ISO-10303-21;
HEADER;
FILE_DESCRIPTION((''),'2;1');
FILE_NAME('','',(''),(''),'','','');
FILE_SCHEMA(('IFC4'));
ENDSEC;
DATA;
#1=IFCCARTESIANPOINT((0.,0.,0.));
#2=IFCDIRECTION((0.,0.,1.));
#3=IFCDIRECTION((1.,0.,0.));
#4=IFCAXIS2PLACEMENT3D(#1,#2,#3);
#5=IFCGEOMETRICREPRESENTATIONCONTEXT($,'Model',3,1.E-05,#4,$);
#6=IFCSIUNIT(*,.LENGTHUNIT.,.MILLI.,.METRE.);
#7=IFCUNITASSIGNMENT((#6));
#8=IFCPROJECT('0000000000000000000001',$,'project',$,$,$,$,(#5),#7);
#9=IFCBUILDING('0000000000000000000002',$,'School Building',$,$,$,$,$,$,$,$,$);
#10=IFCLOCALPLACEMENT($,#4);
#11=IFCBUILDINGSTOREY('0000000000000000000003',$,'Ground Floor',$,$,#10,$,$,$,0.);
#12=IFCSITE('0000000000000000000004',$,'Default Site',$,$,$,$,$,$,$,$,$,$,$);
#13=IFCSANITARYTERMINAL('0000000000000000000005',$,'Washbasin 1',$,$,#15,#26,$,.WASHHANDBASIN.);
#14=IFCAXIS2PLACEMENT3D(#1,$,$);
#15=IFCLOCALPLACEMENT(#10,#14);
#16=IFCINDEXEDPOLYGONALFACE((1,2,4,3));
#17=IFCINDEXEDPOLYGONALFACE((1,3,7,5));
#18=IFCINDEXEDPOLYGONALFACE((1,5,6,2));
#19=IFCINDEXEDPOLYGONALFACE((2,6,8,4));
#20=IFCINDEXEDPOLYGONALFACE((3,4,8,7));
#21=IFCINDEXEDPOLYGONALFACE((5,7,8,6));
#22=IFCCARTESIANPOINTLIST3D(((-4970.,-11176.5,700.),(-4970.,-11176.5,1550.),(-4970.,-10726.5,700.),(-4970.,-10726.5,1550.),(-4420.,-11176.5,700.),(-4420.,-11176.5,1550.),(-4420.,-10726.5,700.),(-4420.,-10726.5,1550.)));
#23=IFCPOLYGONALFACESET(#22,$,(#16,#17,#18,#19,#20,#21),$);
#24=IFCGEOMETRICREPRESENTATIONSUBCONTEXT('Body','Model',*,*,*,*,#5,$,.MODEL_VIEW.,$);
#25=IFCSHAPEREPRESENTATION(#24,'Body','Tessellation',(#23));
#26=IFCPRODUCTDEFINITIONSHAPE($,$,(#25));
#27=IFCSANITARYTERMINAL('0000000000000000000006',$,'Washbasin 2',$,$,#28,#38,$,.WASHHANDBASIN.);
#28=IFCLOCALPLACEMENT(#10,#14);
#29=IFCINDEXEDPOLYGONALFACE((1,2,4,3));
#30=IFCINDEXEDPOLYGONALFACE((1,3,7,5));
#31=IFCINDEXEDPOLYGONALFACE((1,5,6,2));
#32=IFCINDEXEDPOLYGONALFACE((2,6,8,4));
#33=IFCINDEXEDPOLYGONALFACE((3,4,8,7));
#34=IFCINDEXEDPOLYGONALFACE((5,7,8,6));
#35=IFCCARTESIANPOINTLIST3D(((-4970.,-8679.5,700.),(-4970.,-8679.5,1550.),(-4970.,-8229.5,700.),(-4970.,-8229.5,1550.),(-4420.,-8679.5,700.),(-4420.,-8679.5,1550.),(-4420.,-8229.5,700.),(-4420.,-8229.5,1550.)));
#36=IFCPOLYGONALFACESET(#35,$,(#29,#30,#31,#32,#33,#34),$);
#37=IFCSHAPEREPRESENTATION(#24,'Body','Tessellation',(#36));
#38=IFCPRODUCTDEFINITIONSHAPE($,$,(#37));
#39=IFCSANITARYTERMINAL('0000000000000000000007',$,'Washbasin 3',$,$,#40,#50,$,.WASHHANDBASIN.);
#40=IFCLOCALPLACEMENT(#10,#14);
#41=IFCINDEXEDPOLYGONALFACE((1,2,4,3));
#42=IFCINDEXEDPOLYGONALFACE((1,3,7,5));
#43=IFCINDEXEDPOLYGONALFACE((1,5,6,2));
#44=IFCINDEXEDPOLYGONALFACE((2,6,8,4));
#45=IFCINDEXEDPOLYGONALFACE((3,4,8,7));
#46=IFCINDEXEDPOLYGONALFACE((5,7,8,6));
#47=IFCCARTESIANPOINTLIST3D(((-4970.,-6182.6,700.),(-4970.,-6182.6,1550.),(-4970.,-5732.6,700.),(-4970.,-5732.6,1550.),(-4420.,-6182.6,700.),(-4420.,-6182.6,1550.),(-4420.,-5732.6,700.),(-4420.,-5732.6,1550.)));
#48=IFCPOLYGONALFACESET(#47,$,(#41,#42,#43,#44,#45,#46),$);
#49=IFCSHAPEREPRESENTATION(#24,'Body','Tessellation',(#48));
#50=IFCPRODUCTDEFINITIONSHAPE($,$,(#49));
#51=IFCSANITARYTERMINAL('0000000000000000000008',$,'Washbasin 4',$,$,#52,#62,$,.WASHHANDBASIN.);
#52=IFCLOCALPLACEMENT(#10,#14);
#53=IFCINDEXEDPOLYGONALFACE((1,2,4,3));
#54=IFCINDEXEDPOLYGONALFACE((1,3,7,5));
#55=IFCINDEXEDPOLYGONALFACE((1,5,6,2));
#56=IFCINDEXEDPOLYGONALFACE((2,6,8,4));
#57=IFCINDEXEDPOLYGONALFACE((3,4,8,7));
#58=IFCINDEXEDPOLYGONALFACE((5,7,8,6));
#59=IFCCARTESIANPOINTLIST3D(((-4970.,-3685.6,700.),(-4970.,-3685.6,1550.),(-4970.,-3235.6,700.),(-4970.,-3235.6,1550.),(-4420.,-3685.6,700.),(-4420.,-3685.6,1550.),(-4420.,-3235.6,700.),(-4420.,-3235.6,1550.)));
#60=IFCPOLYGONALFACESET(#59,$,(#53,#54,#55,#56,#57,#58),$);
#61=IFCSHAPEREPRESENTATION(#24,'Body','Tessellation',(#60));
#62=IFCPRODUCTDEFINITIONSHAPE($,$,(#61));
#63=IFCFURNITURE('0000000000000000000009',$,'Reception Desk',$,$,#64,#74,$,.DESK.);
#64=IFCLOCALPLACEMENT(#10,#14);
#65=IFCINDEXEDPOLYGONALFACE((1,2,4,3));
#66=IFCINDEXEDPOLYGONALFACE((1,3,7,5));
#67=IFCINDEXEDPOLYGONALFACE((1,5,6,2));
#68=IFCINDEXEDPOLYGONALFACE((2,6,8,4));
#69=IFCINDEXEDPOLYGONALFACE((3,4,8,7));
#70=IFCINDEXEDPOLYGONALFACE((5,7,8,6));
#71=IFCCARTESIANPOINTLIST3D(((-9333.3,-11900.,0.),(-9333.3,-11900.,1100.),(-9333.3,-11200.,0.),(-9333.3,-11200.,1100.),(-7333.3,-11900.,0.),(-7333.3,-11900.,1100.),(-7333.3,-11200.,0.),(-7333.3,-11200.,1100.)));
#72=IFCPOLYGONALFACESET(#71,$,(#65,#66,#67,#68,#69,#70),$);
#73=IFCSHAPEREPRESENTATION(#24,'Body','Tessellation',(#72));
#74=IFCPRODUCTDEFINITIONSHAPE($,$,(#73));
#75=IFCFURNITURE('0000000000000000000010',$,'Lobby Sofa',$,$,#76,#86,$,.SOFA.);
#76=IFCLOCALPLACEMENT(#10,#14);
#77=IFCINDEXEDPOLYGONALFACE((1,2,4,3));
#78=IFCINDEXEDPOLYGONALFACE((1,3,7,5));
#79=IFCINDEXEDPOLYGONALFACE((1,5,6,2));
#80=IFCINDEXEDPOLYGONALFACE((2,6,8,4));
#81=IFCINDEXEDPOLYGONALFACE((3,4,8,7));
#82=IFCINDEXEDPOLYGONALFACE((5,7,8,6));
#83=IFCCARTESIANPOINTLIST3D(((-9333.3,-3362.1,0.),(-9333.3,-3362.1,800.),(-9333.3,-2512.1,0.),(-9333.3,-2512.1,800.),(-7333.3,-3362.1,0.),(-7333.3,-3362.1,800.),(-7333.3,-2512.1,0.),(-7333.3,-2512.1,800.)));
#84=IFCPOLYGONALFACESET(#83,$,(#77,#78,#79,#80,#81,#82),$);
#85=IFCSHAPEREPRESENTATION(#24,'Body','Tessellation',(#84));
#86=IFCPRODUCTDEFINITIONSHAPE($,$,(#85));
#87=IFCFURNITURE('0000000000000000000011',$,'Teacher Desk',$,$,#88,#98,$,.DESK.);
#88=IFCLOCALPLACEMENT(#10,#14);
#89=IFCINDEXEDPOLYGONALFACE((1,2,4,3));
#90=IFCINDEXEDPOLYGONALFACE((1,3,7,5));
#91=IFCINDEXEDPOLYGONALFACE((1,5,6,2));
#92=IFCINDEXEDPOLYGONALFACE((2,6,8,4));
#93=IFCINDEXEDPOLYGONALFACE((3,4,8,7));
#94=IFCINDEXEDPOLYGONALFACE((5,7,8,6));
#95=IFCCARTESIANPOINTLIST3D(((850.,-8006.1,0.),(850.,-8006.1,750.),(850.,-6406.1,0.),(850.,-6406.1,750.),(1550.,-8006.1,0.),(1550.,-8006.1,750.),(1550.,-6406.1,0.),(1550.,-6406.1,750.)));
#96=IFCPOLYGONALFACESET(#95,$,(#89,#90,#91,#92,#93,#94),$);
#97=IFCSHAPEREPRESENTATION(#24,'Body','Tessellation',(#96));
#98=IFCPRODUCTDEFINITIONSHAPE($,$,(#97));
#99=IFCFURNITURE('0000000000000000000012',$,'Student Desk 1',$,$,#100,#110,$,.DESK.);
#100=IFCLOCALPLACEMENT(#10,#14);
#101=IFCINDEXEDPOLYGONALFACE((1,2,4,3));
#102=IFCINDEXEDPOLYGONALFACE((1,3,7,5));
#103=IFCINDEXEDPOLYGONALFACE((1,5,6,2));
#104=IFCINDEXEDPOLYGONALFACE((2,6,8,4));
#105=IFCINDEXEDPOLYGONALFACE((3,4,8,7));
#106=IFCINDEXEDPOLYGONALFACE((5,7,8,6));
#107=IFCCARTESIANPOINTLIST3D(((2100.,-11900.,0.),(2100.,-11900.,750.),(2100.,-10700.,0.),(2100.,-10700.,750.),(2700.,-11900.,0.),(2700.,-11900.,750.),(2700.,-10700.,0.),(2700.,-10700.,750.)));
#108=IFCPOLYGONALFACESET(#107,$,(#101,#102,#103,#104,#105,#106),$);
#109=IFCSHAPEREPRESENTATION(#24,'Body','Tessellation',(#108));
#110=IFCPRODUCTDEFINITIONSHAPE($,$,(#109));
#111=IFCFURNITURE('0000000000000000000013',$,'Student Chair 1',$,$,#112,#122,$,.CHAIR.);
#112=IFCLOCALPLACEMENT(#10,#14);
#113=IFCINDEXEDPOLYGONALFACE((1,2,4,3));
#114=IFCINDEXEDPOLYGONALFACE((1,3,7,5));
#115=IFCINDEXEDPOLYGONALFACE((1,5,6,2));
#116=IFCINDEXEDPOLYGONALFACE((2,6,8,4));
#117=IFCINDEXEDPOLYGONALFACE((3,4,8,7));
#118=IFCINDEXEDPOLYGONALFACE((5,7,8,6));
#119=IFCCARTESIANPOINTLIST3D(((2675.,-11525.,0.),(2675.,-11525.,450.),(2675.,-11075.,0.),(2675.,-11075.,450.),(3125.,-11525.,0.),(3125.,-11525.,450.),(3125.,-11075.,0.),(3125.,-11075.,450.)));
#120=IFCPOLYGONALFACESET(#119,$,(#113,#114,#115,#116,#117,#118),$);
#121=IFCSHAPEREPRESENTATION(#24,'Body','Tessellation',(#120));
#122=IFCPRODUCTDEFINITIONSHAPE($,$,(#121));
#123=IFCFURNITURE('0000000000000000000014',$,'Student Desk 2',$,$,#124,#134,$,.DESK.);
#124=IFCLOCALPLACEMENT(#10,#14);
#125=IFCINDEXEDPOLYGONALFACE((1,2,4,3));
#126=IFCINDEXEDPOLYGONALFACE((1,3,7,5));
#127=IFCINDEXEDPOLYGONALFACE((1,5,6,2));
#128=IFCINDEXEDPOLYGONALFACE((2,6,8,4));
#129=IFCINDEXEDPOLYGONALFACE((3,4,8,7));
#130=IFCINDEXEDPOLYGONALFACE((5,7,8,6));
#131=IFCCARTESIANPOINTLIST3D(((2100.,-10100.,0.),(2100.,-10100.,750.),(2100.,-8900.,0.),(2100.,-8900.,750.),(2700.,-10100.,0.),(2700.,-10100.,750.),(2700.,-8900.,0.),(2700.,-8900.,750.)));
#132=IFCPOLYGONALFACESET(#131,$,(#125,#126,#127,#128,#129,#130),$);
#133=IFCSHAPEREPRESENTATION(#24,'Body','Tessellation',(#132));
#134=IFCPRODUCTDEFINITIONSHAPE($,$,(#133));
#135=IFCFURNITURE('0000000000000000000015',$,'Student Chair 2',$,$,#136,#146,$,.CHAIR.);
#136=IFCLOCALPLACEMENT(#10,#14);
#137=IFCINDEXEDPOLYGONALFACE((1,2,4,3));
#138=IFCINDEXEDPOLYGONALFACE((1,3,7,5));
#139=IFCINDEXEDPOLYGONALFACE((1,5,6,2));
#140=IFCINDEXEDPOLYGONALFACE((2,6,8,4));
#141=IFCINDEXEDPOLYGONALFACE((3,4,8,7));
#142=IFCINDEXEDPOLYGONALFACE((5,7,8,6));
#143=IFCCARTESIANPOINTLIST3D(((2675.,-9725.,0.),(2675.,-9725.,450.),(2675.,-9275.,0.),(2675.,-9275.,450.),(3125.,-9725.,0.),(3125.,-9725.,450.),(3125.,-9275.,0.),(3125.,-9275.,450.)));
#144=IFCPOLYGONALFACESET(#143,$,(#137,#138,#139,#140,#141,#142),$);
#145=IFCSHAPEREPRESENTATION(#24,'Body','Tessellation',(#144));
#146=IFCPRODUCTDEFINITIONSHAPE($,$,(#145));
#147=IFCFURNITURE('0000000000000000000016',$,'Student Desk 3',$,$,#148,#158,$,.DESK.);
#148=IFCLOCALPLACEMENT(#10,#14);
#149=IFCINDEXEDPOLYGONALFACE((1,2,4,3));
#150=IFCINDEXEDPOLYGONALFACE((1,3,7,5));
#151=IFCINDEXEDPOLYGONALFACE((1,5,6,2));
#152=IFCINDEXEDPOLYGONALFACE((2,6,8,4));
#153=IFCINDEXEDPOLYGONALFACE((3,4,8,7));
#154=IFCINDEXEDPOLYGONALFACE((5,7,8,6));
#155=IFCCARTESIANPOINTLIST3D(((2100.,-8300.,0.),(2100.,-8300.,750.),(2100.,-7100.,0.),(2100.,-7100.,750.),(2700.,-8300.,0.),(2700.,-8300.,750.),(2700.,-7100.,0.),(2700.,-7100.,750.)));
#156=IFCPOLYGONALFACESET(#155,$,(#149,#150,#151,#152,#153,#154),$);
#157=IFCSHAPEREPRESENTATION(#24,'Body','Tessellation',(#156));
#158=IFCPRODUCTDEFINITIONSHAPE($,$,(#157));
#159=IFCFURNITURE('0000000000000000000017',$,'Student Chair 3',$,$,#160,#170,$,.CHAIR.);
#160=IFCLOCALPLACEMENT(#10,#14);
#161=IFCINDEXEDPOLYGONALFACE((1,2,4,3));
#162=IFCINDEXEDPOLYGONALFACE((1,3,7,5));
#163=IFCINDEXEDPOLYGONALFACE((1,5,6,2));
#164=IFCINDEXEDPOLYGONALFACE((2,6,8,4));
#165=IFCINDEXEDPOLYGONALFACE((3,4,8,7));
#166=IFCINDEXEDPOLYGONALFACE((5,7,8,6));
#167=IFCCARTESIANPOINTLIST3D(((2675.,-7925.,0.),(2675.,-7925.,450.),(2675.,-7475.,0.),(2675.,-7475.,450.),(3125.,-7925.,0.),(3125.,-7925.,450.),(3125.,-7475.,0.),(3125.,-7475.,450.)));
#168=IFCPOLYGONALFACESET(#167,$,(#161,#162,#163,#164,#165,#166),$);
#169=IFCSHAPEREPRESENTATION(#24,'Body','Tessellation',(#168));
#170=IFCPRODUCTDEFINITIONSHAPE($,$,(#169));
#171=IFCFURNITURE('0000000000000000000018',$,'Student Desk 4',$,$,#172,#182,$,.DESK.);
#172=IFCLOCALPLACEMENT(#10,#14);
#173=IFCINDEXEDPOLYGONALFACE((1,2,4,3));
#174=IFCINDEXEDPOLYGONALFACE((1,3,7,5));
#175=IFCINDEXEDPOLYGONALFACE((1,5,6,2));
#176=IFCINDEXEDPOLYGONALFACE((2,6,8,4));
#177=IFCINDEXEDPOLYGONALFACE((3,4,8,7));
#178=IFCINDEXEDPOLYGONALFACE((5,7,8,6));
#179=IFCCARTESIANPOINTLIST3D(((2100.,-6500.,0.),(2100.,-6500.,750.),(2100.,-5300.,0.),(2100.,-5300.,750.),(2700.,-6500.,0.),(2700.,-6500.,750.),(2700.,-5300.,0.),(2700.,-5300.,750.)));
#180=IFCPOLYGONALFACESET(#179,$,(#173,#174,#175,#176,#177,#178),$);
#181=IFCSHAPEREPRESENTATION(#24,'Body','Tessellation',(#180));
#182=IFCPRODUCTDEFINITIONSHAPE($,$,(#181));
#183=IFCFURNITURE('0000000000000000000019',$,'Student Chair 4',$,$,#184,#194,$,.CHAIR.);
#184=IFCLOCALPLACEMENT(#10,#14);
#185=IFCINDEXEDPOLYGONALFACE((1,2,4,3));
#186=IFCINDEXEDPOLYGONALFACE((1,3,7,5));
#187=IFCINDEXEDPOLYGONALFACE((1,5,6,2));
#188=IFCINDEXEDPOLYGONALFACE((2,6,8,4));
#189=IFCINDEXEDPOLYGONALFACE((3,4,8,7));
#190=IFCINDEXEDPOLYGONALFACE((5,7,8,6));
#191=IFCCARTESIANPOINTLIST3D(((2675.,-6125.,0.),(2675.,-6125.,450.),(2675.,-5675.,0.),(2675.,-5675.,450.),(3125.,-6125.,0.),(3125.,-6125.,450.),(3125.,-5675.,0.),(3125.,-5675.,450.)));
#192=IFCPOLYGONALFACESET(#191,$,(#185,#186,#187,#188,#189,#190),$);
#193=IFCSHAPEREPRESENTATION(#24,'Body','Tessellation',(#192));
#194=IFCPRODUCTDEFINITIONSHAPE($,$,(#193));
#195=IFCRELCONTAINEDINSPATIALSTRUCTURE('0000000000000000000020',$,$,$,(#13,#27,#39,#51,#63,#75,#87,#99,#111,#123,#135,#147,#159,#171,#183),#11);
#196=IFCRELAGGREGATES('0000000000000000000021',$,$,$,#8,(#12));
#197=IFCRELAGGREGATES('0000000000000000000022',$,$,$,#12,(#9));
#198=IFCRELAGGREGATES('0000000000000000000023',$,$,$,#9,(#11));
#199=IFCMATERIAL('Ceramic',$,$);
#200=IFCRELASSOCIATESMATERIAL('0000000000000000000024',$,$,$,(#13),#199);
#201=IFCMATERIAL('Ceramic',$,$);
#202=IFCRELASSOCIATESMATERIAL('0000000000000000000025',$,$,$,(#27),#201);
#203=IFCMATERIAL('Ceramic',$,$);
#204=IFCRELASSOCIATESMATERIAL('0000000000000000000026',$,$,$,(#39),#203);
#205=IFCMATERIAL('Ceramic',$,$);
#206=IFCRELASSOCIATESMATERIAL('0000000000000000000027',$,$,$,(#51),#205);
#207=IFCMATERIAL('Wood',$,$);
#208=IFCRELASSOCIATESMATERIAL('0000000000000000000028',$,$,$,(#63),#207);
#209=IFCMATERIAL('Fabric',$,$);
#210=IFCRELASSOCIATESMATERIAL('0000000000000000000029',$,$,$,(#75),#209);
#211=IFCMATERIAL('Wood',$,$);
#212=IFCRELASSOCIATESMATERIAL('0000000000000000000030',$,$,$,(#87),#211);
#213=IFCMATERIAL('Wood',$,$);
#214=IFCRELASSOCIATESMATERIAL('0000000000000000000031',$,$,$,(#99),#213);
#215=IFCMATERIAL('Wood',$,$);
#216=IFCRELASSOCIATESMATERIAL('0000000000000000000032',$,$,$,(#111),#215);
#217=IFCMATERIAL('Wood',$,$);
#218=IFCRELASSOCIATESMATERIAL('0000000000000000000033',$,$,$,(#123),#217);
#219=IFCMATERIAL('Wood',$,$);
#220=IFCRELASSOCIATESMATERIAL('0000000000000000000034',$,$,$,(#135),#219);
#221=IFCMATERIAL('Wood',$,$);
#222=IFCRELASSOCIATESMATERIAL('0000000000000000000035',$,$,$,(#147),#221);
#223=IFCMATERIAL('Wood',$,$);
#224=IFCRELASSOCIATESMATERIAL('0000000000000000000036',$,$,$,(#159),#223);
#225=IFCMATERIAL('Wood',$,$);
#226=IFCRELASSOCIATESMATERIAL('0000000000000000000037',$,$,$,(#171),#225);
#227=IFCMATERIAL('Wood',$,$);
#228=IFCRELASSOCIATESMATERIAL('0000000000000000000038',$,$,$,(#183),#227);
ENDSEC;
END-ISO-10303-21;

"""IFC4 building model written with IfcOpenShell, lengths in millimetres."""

from ifc_helpers import new_model, si_unit, frame, origin_with_axes, origin_2d, place, context, subcontext, project, spatial, rectangle, extrude, material, element, save


model = new_model("IFC4")

# Units and contexts
model_context = context("Model", 3, precision=1e-05, world=origin_with_axes())
body_context = subcontext(model_context, "Body", "Model", "MODEL_VIEW")
ifc_project = project(units=[si_unit("LENGTHUNIT", "METRE", prefix="MILLI")], contexts=[model_context])

# Site, building, storey
site = spatial("IfcSite", under=ifc_project, Name="Default Site")
building = spatial("IfcBuilding", under=site, Name="School Building")
storey_placement = place(None, origin_with_axes())
storey = spatial("IfcBuildingStorey", under=building, at=storey_placement, Name="Ground Floor", Elevation=0.0)

# Sanitary terminals
ifc_material_1 = material(Name="Ceramic")
sanitary_terminal_1_placement = place(storey_placement, frame((-4695.0, -10951.5, 700.0), z_axis=(0.0, 0.0, 1.0), x_axis=(0.0, 1.0, 0.0)))
element("IfcSanitaryTerminal", 1, at=sanitary_terminal_1_placement, inside=storey, material=ifc_material_1, Name="Washbasin 1", PredefinedType="WASHHANDBASIN", context=body_context, shape_type="SweptSolid", body=[
    extrude(rectangle(XDim=450.0, YDim=550.0, at=origin_2d()), origin_with_axes(), (0.0, 0.0, 1.0), 850.0),
])
ifc_material_2 = material(Name="Ceramic")
sanitary_terminal_2_placement = place(storey_placement, frame((-4695.0, -8454.5, 700.0), z_axis=(0.0, 0.0, 1.0), x_axis=(0.0, 1.0, 0.0)))
element("IfcSanitaryTerminal", 2, at=sanitary_terminal_2_placement, inside=storey, material=ifc_material_2, Name="Washbasin 2", PredefinedType="WASHHANDBASIN", context=body_context, shape_type="SweptSolid", body=[
    extrude(rectangle(XDim=450.0, YDim=550.0, at=origin_2d()), origin_with_axes(), (0.0, 0.0, 1.0), 850.0),
])
ifc_material_3 = material(Name="Ceramic")
sanitary_terminal_3_placement = place(storey_placement, frame((-4695.0, -5957.6, 700.0), z_axis=(0.0, 0.0, 1.0), x_axis=(0.0, 1.0, 0.0)))
element("IfcSanitaryTerminal", 3, at=sanitary_terminal_3_placement, inside=storey, material=ifc_material_3, Name="Washbasin 3", PredefinedType="WASHHANDBASIN", context=body_context, shape_type="SweptSolid", body=[
    extrude(rectangle(XDim=450.0, YDim=550.0, at=origin_2d()), origin_with_axes(), (0.0, 0.0, 1.0), 850.0),
])
ifc_material_4 = material(Name="Ceramic")
sanitary_terminal_4_placement = place(storey_placement, frame((-4695.0, -3460.6, 700.0), z_axis=(0.0, 0.0, 1.0), x_axis=(0.0, 1.0, 0.0)))
element("IfcSanitaryTerminal", 4, at=sanitary_terminal_4_placement, inside=storey, material=ifc_material_4, Name="Washbasin 4", PredefinedType="WASHHANDBASIN", context=body_context, shape_type="SweptSolid", body=[
    extrude(rectangle(XDim=450.0, YDim=550.0, at=origin_2d()), origin_with_axes(), (0.0, 0.0, 1.0), 850.0),
])

# Furniture
ifc_material_5 = material(Name="Wood")
furniture_1_placement = place(storey_placement, frame((-8333.3, -11550.0, 0.0), z_axis=(0.0, 0.0, 1.0), x_axis=(1.0, 0.0, 0.0)))
element("IfcFurniture", 5, at=furniture_1_placement, inside=storey, material=ifc_material_5, Name="Reception Desk", PredefinedType="DESK", context=body_context, shape_type="SweptSolid", body=[
    extrude(rectangle(XDim=2000.0, YDim=700.0, at=origin_2d()), origin_with_axes(), (0.0, 0.0, 1.0), 1100.0),
])
ifc_material_6 = material(Name="Fabric")
furniture_2_placement = place(storey_placement, frame((-8333.3, -2937.1, 0.0), z_axis=(0.0, 0.0, 1.0), x_axis=(1.0, 0.0, 0.0)))
element("IfcFurniture", 6, at=furniture_2_placement, inside=storey, material=ifc_material_6, Name="Lobby Sofa", PredefinedType="SOFA", context=body_context, shape_type="SweptSolid", body=[
    extrude(rectangle(XDim=2000.0, YDim=850.0, at=origin_2d()), origin_with_axes(), (0.0, 0.0, 1.0), 800.0),
])
ifc_material_7 = material(Name="Wood")
furniture_3_placement = place(storey_placement, frame((1200.0, -7206.1, 0.0), z_axis=(0.0, 0.0, 1.0), x_axis=(0.0, 1.0, 0.0)))
element("IfcFurniture", 7, at=furniture_3_placement, inside=storey, material=ifc_material_7, Name="Teacher Desk", PredefinedType="DESK", context=body_context, shape_type="SweptSolid", body=[
    extrude(rectangle(XDim=1600.0, YDim=700.0, at=origin_2d()), origin_with_axes(), (0.0, 0.0, 1.0), 750.0),
])
ifc_material_8 = material(Name="Wood")
furniture_4_placement = place(storey_placement, frame((2400.0, -11300.0, 0.0), z_axis=(0.0, 0.0, 1.0), x_axis=(0.0, 1.0, 0.0)))
element("IfcFurniture", 8, at=furniture_4_placement, inside=storey, material=ifc_material_8, Name="Student Desk 1", PredefinedType="DESK", context=body_context, shape_type="SweptSolid", body=[
    extrude(rectangle(XDim=1200.0, YDim=600.0, at=origin_2d()), origin_with_axes(), (0.0, 0.0, 1.0), 750.0),
])
ifc_material_9 = material(Name="Wood")
furniture_5_placement = place(storey_placement, frame((2900.0, -11300.0, 0.0), z_axis=(0.0, 0.0, 1.0), x_axis=(1.0, 0.0, 0.0)))
element("IfcFurniture", 9, at=furniture_5_placement, inside=storey, material=ifc_material_9, Name="Student Chair 1", PredefinedType="CHAIR", context=body_context, shape_type="SweptSolid", body=[
    extrude(rectangle(XDim=450.0, YDim=450.0, at=origin_2d()), origin_with_axes(), (0.0, 0.0, 1.0), 450.0),
])
ifc_material_10 = material(Name="Wood")
furniture_6_placement = place(storey_placement, frame((2400.0, -9500.0, 0.0), z_axis=(0.0, 0.0, 1.0), x_axis=(0.0, 1.0, 0.0)))
element("IfcFurniture", 10, at=furniture_6_placement, inside=storey, material=ifc_material_10, Name="Student Desk 2", PredefinedType="DESK", context=body_context, shape_type="SweptSolid", body=[
    extrude(rectangle(XDim=1200.0, YDim=600.0, at=origin_2d()), origin_with_axes(), (0.0, 0.0, 1.0), 750.0),
])
ifc_material_11 = material(Name="Wood")
furniture_7_placement = place(storey_placement, frame((2900.0, -9500.0, 0.0), z_axis=(0.0, 0.0, 1.0), x_axis=(1.0, 0.0, 0.0)))
element("IfcFurniture", 11, at=furniture_7_placement, inside=storey, material=ifc_material_11, Name="Student Chair 2", PredefinedType="CHAIR", context=body_context, shape_type="SweptSolid", body=[
    extrude(rectangle(XDim=450.0, YDim=450.0, at=origin_2d()), origin_with_axes(), (0.0, 0.0, 1.0), 450.0),
])
ifc_material_12 = material(Name="Wood")
furniture_8_placement = place(storey_placement, frame((2400.0, -7700.0, 0.0), z_axis=(0.0, 0.0, 1.0), x_axis=(0.0, 1.0, 0.0)))
element("IfcFurniture", 12, at=furniture_8_placement, inside=storey, material=ifc_material_12, Name="Student Desk 3", PredefinedType="DESK", context=body_context, shape_type="SweptSolid", body=[
    extrude(rectangle(XDim=1200.0, YDim=600.0, at=origin_2d()), origin_with_axes(), (0.0, 0.0, 1.0), 750.0),
])
ifc_material_13 = material(Name="Wood")
furniture_9_placement = place(storey_placement, frame((2900.0, -7700.0, 0.0), z_axis=(0.0, 0.0, 1.0), x_axis=(1.0, 0.0, 0.0)))
element("IfcFurniture", 13, at=furniture_9_placement, inside=storey, material=ifc_material_13, Name="Student Chair 3", PredefinedType="CHAIR", context=body_context, shape_type="SweptSolid", body=[
    extrude(rectangle(XDim=450.0, YDim=450.0, at=origin_2d()), origin_with_axes(), (0.0, 0.0, 1.0), 450.0),
])
ifc_material_14 = material(Name="Wood")
furniture_10_placement = place(storey_placement, frame((2400.0, -5900.0, 0.0), z_axis=(0.0, 0.0, 1.0), x_axis=(0.0, 1.0, 0.0)))
element("IfcFurniture", 14, at=furniture_10_placement, inside=storey, material=ifc_material_14, Name="Student Desk 4", PredefinedType="DESK", context=body_context, shape_type="SweptSolid", body=[
    extrude(rectangle(XDim=1200.0, YDim=600.0, at=origin_2d()), origin_with_axes(), (0.0, 0.0, 1.0), 750.0),
])
ifc_material_15 = material(Name="Wood")
furniture_11_placement = place(storey_placement, frame((2900.0, -5900.0, 0.0), z_axis=(0.0, 0.0, 1.0), x_axis=(1.0, 0.0, 0.0)))
element("IfcFurniture", 15, at=furniture_11_placement, inside=storey, material=ifc_material_15, Name="Student Chair 4", PredefinedType="CHAIR", context=body_context, shape_type="SweptSolid", body=[
    extrude(rectangle(XDim=450.0, YDim=450.0, at=origin_2d()), origin_with_axes(), (0.0, 0.0, 1.0), 450.0),
])

save(model, "model.ifc")
